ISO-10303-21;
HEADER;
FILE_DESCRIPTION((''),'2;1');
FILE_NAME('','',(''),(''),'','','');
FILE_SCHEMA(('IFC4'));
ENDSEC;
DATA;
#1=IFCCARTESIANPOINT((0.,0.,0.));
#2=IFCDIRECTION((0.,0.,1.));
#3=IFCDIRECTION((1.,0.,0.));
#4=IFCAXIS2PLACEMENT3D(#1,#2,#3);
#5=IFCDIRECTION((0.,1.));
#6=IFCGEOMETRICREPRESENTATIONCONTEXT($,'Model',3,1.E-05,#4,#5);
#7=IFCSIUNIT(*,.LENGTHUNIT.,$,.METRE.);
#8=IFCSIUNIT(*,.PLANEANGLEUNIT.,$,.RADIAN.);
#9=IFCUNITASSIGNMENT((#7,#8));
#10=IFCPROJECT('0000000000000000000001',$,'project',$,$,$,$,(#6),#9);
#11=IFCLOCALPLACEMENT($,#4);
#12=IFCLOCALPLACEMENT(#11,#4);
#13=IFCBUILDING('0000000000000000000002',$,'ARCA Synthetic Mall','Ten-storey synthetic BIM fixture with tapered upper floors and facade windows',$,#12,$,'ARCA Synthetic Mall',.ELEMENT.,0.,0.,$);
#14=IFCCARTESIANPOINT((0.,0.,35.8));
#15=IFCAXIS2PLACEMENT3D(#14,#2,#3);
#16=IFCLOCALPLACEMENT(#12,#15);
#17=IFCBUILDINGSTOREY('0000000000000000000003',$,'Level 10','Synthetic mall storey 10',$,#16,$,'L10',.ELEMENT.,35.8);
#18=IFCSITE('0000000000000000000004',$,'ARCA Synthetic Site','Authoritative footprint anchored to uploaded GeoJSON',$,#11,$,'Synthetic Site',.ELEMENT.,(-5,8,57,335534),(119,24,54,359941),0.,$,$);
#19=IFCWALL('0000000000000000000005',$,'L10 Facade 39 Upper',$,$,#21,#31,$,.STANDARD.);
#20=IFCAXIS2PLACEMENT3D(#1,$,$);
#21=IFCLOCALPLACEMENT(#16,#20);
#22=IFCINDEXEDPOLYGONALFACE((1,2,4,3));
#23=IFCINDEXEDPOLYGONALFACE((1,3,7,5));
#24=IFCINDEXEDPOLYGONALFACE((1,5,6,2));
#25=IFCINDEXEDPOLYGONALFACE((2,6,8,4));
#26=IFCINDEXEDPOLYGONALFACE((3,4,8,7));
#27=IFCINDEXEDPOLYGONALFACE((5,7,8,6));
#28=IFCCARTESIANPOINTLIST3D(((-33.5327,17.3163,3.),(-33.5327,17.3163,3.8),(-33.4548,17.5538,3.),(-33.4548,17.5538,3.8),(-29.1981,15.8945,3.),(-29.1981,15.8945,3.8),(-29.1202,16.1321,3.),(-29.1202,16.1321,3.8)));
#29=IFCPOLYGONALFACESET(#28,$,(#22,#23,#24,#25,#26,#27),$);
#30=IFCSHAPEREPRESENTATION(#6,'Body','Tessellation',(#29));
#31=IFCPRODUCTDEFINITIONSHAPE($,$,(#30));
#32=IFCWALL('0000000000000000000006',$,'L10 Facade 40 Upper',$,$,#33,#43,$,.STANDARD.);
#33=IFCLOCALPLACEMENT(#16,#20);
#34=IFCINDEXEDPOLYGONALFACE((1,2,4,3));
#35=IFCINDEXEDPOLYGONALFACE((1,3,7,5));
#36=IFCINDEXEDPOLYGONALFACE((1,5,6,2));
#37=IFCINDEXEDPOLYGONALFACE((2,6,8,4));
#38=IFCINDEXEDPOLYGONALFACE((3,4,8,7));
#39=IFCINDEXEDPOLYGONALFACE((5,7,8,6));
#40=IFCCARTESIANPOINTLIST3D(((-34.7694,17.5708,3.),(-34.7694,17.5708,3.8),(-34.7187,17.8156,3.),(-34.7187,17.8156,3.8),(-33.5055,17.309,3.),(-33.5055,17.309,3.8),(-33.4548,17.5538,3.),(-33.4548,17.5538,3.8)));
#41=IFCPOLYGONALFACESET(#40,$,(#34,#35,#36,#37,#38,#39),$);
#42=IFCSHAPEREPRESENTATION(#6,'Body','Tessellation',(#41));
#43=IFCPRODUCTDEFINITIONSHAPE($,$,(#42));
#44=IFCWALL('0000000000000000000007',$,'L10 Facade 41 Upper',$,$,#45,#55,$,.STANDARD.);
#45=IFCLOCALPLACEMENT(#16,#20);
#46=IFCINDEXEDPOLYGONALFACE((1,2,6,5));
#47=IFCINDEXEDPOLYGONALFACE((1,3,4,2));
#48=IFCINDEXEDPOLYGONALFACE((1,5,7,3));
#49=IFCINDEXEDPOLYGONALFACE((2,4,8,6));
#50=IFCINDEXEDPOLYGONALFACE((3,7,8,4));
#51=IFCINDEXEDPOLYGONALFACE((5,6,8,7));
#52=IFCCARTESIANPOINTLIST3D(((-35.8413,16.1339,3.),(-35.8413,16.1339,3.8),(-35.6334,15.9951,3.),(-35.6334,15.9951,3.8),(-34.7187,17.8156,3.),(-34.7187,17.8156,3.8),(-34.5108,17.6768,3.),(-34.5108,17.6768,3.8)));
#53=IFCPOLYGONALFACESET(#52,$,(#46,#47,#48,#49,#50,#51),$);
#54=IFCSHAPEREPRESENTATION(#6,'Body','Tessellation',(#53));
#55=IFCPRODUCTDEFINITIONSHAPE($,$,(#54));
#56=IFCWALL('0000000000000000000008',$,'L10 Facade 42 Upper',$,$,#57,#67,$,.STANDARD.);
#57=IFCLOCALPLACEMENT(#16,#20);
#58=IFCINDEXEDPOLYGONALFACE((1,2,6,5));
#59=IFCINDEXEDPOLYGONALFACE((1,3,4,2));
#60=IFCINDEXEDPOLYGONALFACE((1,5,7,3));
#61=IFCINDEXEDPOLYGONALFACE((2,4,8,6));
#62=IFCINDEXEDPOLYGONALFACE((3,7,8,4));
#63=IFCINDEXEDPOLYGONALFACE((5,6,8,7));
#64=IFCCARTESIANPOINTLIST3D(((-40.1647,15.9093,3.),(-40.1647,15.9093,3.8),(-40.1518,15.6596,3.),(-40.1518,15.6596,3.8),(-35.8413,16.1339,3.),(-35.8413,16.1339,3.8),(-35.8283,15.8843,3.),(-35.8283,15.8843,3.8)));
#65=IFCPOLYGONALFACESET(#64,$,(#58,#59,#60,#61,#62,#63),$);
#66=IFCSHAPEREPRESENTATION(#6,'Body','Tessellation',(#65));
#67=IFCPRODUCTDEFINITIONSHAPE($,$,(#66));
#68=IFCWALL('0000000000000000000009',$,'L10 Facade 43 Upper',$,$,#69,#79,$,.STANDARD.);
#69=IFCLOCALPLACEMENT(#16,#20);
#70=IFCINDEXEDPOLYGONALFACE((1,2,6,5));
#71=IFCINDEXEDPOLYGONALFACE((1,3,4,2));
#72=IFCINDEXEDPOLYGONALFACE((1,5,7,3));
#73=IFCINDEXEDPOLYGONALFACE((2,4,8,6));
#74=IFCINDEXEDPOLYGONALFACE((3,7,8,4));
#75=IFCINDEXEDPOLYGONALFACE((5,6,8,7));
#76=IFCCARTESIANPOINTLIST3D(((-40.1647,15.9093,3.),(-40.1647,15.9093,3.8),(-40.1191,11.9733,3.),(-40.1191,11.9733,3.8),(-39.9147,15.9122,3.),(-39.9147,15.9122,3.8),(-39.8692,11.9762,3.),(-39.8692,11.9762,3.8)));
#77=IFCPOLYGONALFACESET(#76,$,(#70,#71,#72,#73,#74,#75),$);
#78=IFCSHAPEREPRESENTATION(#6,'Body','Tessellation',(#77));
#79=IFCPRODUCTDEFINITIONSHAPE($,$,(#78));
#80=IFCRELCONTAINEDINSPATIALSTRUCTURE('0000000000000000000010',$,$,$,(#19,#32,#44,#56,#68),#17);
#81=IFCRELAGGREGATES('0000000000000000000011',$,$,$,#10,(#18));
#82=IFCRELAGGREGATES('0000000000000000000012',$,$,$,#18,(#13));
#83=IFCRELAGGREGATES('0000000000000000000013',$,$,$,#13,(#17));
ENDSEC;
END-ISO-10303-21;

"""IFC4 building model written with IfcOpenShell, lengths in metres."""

from ifc_helpers import new_model, si_unit, direction, frame, origin_with_axes, place, context, project, spatial, polyline, outline, extrude, element, save


model = new_model("IFC4")

# Units and contexts
model_context = context("Model", 3, precision=1e-05, world=origin_with_axes(), true_north=direction((0.0, 1.0)))
ifc_project = project(units=[si_unit("LENGTHUNIT", "METRE"), si_unit("PLANEANGLEUNIT", "RADIAN")], contexts=[model_context])

# Site, building, storey
site_placement = place(None, origin_with_axes())
site = spatial("IfcSite", under=ifc_project, at=site_placement, Name="ARCA Synthetic Site", Description="Authoritative footprint anchored to uploaded GeoJSON", LongName="Synthetic Site", CompositionType="ELEMENT", RefLatitude=(-5, 8, 57, 335534), RefLongitude=(119, 24, 54, 359941), RefElevation=0.0)
building_placement = place(site_placement, origin_with_axes())
building = spatial("IfcBuilding", under=site, at=building_placement, Name="ARCA Synthetic Mall", Description="Ten-storey synthetic BIM fixture with tapered upper floors and facade windows", LongName="ARCA Synthetic Mall", CompositionType="ELEMENT", ElevationOfRefHeight=0.0, ElevationOfTerrain=0.0)
storey_placement = place(building_placement, frame((0.0, 0.0, 35.8), z_axis=(0.0, 0.0, 1.0), x_axis=(1.0, 0.0, 0.0)))
storey = spatial("IfcBuildingStorey", under=building, at=storey_placement, Name="Level 10", Description="Synthetic mall storey 10", LongName="L10", CompositionType="ELEMENT", Elevation=35.8)

# Walls
wall_1_placement = place(storey_placement, frame((0.0, 0.0, 3.0), z_axis=(0.0, 0.0, 1.0), x_axis=(1.0, 0.0, 0.0)))
element("IfcWall", 1, at=wall_1_placement, inside=storey, Name="L10 Facade 39 Upper", PredefinedType="STANDARD", context=model_context, shape_type="SweptSolid", body=[
    extrude(outline(polyline([(-29.1202, 16.1321), (-33.4548, 17.5538), (-33.5327, 17.3163), (-29.1981, 15.8945), (-29.1202, 16.1321)])), origin_with_axes(), (0.0, 0.0, 1.0), 0.8),
])
wall_2_placement = place(storey_placement, frame((0.0, 0.0, 3.0), z_axis=(0.0, 0.0, 1.0), x_axis=(1.0, 0.0, 0.0)))
element("IfcWall", 2, at=wall_2_placement, inside=storey, Name="L10 Facade 40 Upper", PredefinedType="STANDARD", context=model_context, shape_type="SweptSolid", body=[
    extrude(outline(polyline([(-33.4548, 17.5538), (-34.7187, 17.8156), (-34.7694, 17.5708), (-33.5055, 17.309), (-33.4548, 17.5538)])), origin_with_axes(), (0.0, 0.0, 1.0), 0.8),
])
wall_3_placement = place(storey_placement, frame((0.0, 0.0, 3.0), z_axis=(0.0, 0.0, 1.0), x_axis=(1.0, 0.0, 0.0)))
element("IfcWall", 3, at=wall_3_placement, inside=storey, Name="L10 Facade 41 Upper", PredefinedType="STANDARD", context=model_context, shape_type="SweptSolid", body=[
    extrude(outline(polyline([(-34.7187, 17.8156), (-35.8413, 16.1339), (-35.6334, 15.9951), (-34.5108, 17.6768), (-34.7187, 17.8156)])), origin_with_axes(), (0.0, 0.0, 1.0), 0.8),
])
wall_4_placement = place(storey_placement, frame((0.0, 0.0, 3.0), z_axis=(0.0, 0.0, 1.0), x_axis=(1.0, 0.0, 0.0)))
element("IfcWall", 4, at=wall_4_placement, inside=storey, Name="L10 Facade 42 Upper", PredefinedType="STANDARD", context=model_context, shape_type="SweptSolid", body=[
    extrude(outline(polyline([(-35.8413, 16.1339), (-40.1647, 15.9093), (-40.1518, 15.6596), (-35.8283, 15.8843), (-35.8413, 16.1339)])), origin_with_axes(), (0.0, 0.0, 1.0), 0.8),
])
wall_5_placement = place(storey_placement, frame((0.0, 0.0, 3.0), z_axis=(0.0, 0.0, 1.0), x_axis=(1.0, 0.0, 0.0)))
element("IfcWall", 5, at=wall_5_placement, inside=storey, Name="L10 Facade 43 Upper", PredefinedType="STANDARD", context=model_context, shape_type="SweptSolid", body=[
    extrude(outline(polyline([(-40.1647, 15.9093), (-40.1191, 11.9733), (-39.8692, 11.9762), (-39.9147, 15.9122), (-40.1647, 15.9093)])), origin_with_axes(), (0.0, 0.0, 1.0), 0.8),
])

save(model, "model.ifc")
